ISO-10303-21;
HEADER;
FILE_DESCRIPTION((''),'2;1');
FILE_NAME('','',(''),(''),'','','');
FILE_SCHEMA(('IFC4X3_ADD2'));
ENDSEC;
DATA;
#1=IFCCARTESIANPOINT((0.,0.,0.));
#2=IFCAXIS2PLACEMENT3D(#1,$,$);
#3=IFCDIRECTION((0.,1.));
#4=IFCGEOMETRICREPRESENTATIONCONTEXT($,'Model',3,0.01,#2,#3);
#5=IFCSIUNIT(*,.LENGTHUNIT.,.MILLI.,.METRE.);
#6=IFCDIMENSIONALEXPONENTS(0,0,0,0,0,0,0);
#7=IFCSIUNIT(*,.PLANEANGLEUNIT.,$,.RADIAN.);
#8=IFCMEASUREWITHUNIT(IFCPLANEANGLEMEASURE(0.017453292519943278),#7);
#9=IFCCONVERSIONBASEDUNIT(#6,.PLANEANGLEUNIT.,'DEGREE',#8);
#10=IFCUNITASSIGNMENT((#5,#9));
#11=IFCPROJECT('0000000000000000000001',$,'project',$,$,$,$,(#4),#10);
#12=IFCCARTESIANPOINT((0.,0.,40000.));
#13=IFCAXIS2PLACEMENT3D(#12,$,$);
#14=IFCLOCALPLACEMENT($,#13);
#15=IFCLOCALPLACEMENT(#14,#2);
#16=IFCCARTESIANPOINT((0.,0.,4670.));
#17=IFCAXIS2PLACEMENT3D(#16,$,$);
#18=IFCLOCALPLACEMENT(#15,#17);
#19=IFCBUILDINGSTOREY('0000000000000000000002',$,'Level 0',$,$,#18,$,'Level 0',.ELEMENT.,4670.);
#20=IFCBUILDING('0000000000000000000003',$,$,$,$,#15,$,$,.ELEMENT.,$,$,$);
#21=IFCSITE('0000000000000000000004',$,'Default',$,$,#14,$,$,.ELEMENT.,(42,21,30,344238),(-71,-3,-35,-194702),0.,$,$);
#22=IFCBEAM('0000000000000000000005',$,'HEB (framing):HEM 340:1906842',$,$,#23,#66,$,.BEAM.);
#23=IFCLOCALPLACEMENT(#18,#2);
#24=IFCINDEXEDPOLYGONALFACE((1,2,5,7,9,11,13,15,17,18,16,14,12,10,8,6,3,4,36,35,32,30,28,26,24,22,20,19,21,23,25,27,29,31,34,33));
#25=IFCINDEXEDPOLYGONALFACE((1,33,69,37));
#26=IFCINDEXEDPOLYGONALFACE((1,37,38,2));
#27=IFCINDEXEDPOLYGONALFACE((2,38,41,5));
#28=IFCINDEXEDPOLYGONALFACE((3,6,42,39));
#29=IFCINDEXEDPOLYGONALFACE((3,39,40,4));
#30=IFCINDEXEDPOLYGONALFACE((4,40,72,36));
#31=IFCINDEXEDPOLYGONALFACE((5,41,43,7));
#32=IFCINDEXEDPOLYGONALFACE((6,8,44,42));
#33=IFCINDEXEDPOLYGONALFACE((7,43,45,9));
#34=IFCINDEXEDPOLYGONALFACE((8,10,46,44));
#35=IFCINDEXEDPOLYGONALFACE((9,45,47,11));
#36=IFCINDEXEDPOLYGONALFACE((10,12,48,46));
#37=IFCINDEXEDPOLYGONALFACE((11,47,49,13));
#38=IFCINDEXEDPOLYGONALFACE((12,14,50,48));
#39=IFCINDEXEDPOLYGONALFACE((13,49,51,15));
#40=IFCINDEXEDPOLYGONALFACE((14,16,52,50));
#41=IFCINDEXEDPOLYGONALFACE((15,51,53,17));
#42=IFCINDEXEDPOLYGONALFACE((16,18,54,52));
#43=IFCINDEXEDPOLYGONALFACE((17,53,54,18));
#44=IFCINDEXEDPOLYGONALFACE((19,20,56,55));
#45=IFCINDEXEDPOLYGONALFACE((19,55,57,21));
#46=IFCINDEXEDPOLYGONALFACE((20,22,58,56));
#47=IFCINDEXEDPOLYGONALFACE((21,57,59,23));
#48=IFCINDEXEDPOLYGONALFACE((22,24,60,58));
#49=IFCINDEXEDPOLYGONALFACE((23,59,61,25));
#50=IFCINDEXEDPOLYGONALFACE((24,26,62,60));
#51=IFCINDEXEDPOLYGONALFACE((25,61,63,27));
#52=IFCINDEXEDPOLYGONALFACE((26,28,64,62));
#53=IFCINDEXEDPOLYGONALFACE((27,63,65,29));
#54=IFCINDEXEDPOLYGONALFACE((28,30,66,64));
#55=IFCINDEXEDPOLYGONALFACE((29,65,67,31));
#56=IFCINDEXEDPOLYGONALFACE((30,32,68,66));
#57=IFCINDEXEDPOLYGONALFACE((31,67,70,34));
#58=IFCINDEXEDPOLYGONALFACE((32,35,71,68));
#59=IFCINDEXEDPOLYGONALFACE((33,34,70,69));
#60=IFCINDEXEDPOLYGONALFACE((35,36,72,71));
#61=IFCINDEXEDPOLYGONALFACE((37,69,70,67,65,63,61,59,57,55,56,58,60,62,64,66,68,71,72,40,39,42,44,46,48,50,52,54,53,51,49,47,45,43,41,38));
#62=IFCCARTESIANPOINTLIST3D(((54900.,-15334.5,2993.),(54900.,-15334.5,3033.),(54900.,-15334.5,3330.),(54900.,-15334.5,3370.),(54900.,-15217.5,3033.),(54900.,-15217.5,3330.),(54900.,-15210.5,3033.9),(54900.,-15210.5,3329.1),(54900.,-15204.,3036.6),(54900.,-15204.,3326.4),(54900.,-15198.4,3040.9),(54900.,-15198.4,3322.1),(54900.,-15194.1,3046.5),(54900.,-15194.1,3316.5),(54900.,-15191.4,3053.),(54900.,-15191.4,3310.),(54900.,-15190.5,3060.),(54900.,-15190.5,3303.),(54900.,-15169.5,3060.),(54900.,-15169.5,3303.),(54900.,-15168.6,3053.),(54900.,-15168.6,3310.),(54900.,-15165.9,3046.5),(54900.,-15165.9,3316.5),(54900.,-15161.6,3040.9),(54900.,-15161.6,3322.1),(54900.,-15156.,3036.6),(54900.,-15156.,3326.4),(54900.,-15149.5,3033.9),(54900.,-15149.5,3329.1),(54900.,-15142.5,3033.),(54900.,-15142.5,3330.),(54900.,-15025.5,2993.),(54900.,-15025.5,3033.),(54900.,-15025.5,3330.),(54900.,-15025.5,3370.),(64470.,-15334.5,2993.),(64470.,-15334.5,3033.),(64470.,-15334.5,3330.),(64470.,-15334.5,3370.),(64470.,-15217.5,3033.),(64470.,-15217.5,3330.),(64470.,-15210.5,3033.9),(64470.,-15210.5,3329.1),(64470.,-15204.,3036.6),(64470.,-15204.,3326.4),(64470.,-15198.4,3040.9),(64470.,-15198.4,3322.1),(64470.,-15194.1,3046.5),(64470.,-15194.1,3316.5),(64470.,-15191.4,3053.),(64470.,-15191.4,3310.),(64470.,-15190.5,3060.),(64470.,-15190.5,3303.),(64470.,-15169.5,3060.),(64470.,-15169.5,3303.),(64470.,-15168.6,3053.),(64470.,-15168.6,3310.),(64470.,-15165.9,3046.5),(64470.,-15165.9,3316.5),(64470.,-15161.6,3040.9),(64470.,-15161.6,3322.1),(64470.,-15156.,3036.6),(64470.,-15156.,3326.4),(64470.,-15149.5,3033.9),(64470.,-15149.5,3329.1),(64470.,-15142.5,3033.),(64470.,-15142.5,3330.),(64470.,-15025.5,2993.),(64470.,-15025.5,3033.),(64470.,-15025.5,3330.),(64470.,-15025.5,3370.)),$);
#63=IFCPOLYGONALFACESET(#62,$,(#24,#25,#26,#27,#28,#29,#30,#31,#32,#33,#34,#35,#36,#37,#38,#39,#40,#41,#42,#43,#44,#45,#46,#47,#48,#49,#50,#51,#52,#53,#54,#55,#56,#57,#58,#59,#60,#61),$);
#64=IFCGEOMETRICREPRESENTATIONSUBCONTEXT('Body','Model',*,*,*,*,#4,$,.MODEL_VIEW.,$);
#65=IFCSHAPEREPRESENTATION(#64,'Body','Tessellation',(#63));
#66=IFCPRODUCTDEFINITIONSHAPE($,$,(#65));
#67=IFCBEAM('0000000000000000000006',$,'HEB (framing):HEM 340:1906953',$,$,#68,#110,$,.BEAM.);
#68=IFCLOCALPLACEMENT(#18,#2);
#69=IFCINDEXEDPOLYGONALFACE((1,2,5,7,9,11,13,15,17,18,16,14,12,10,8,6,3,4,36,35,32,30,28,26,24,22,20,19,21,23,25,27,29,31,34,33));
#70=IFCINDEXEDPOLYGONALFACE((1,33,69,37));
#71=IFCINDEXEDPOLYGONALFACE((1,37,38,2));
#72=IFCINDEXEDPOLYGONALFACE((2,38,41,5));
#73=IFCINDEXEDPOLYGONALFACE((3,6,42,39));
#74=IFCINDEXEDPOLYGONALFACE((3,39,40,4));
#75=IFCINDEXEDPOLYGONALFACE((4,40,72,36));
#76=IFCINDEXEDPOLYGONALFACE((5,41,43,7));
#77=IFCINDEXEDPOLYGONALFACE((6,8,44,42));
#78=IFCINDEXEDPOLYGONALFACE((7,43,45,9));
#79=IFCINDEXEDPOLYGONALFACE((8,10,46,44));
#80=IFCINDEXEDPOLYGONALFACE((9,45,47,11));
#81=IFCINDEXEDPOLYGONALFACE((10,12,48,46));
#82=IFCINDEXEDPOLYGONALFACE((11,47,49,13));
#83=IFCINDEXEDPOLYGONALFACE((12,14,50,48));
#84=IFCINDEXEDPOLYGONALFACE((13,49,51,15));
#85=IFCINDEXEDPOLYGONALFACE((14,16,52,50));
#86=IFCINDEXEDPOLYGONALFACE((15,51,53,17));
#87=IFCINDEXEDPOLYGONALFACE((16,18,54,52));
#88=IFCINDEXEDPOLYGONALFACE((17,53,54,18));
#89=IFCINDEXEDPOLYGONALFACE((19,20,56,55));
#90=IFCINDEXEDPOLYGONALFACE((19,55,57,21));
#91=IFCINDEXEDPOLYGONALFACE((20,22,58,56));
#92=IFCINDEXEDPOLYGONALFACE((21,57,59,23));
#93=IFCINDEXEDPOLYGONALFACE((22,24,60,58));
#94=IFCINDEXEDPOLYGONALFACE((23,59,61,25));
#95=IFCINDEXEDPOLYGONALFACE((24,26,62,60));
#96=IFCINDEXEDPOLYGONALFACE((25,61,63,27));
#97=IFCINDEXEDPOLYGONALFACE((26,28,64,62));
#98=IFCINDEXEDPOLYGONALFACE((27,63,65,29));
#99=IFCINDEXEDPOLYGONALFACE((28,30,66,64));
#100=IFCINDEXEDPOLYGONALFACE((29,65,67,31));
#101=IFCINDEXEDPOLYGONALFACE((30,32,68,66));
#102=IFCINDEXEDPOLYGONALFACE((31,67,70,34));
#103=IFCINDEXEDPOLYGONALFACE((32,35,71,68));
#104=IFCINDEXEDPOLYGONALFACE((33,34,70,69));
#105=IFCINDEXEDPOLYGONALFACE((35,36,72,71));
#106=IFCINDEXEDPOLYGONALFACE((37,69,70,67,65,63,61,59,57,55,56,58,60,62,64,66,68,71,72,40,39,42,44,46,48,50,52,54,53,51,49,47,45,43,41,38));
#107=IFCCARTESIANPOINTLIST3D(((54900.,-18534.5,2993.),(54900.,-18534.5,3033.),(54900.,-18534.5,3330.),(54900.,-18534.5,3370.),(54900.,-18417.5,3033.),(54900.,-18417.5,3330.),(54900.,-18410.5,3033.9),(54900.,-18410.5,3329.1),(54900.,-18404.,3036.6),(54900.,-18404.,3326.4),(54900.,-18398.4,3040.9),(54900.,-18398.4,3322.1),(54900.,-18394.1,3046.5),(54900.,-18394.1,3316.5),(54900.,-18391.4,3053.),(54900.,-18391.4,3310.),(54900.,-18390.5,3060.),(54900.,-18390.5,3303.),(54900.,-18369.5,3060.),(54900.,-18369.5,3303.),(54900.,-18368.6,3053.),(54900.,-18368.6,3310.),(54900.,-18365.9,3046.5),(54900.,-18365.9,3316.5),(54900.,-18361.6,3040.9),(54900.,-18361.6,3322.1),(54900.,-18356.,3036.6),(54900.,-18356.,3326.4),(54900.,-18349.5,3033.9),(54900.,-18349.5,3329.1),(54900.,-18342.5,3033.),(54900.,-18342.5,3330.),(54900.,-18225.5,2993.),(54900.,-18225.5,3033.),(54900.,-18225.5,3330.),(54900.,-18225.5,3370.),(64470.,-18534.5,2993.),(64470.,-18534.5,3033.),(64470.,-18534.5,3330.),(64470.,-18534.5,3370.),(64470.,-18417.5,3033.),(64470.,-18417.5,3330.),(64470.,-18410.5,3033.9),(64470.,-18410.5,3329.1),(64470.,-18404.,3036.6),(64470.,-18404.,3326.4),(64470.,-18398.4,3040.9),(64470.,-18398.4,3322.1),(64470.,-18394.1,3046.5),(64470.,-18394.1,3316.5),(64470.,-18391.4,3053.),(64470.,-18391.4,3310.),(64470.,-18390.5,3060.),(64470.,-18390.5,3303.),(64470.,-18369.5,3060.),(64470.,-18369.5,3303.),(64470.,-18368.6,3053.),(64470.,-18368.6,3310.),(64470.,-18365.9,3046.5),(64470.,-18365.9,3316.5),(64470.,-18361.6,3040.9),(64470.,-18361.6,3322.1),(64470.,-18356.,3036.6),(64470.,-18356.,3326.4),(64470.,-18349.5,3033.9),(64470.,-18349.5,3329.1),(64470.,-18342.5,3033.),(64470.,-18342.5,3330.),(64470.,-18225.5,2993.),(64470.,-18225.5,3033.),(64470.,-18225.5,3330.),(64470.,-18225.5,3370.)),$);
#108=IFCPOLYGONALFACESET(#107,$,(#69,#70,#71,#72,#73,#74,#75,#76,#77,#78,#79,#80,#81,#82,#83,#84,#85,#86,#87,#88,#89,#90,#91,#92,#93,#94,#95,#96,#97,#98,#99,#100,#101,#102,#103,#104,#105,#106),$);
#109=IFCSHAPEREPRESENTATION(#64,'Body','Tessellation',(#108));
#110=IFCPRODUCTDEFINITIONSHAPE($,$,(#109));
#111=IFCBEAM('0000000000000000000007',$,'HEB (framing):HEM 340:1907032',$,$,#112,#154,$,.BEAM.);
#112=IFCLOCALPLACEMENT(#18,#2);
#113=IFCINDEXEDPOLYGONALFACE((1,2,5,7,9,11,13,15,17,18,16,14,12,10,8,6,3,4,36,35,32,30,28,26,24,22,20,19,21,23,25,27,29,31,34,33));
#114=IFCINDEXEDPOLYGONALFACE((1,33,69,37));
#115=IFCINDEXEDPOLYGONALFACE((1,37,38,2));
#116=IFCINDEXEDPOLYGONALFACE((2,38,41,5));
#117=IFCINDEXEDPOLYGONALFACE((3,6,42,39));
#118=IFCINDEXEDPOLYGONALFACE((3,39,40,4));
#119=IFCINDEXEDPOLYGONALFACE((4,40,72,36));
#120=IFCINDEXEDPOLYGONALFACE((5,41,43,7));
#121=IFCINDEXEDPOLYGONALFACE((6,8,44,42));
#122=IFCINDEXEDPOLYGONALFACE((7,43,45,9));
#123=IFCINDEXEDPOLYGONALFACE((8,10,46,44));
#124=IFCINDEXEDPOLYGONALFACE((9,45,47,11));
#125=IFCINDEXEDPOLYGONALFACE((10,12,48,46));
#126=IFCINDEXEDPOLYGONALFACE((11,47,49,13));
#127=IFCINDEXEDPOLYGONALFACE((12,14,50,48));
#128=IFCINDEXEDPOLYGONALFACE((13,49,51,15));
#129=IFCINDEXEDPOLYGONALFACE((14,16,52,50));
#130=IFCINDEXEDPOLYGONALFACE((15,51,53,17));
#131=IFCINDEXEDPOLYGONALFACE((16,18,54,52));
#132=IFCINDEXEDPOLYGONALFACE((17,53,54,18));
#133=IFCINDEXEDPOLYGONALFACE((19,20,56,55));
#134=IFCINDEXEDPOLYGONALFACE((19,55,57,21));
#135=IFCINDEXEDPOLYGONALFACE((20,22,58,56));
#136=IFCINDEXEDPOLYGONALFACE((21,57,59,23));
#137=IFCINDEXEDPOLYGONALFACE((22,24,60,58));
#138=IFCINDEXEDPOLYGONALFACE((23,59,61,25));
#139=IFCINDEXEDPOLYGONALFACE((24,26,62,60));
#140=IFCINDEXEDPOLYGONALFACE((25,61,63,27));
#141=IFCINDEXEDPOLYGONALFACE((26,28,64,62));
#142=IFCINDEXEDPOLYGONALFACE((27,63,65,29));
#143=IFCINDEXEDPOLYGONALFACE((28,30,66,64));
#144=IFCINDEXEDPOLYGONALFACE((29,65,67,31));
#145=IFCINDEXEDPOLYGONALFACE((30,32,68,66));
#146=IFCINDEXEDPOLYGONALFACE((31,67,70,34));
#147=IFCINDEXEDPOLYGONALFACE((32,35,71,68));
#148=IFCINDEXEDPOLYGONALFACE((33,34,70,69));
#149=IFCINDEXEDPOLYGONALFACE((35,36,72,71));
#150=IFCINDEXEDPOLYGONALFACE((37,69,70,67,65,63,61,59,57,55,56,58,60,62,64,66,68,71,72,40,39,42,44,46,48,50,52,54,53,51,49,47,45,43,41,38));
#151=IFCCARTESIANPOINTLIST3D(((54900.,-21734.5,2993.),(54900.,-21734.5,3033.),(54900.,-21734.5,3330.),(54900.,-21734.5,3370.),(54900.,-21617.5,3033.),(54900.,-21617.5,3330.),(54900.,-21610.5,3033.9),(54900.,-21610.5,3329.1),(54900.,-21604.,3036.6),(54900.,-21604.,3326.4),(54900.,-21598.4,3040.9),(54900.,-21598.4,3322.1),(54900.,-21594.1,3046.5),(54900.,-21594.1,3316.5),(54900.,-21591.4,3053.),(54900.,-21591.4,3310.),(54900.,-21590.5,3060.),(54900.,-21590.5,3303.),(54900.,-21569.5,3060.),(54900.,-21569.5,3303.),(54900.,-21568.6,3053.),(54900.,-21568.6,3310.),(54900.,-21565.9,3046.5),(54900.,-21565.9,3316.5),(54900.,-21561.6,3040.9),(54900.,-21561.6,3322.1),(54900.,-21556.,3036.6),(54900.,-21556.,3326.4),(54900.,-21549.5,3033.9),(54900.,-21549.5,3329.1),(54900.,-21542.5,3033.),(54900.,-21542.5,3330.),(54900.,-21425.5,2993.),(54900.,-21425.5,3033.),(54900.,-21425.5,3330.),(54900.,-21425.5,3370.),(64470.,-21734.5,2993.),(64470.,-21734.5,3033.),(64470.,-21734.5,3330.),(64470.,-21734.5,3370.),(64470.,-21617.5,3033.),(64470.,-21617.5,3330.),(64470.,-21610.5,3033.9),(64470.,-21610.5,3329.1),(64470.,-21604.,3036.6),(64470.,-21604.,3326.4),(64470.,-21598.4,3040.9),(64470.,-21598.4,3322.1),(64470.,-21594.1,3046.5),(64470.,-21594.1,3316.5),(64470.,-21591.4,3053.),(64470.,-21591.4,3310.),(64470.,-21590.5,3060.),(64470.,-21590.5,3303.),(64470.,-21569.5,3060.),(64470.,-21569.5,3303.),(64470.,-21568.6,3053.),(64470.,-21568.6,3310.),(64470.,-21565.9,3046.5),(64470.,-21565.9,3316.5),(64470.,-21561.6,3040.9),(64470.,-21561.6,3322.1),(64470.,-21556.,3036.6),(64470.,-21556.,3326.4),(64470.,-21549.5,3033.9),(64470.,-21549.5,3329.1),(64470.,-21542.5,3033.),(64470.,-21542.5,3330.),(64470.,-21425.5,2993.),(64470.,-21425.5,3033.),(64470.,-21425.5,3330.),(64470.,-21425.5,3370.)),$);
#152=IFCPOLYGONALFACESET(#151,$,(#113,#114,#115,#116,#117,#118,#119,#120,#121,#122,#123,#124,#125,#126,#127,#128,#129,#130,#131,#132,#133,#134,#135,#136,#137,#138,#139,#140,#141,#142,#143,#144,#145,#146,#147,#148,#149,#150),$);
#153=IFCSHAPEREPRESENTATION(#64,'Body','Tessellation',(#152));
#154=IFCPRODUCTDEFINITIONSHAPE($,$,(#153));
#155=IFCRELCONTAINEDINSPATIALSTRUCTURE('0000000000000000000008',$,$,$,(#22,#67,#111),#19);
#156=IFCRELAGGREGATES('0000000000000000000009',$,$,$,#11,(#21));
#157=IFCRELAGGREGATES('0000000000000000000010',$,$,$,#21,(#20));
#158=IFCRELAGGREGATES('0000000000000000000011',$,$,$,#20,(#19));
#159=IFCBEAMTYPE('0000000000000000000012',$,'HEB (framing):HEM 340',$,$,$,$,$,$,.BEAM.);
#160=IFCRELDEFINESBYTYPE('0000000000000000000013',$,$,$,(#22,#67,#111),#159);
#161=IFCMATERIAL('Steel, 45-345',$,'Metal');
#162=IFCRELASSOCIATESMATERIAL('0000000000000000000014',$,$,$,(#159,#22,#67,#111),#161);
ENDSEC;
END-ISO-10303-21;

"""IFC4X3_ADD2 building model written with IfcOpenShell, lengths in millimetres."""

from ifc_helpers import new_model, entity, si_unit, converted_unit, direction, frame, frame_2d, origin, place, context, subcontext, project, spatial, polyline, circle_curve, parameter, trimmed, segment, composite_curve, outline, extrude, source, transform, mapped, material, material_profile, profile_set, profile_usage, type_object, type_shapes, element, save


model = new_model("IFC4X3_ADD2")

# Units and contexts
model_context = context("Model", 3, precision=0.01, world=origin(), true_north=direction((0.0, 1.0)))
body_context = subcontext(model_context, "Body", "Model", "MODEL_VIEW")
ifc_project = project(units=[si_unit("LENGTHUNIT", "METRE", prefix="MILLI"), converted_unit("PLANEANGLEUNIT", "DEGREE", entity("IfcPlaneAngleMeasure", 0.017453292519943278), si_unit("PLANEANGLEUNIT", "RADIAN"), dimensions=[0, 0, 0, 0, 0, 0, 0])], contexts=[model_context])

# Site, building, storey
site_placement = place(None, frame((0.0, 0.0, 40000.0)))
site = spatial("IfcSite", under=ifc_project, at=site_placement, Name="Default", CompositionType="ELEMENT", RefLatitude=(42, 21, 30, 344238), RefLongitude=(-71, -3, -35, -194702), RefElevation=0.0)
building_placement = place(site_placement, origin())
building = spatial("IfcBuilding", under=site, at=building_placement, CompositionType="ELEMENT")
storey_placement = place(building_placement, frame((0.0, 0.0, 4670.0)))
storey = spatial("IfcBuildingStorey", under=building, at=storey_placement, Name="Level 0", LongName="Level 0", CompositionType="ELEMENT", Elevation=4670.0)

# Shared definitions
ifc_material_1 = material(Name="Steel, 45-345", Category="Metal")

# Beams
ifc_material_profile_1 = material_profile(ifc_material_1, outline(composite_curve([segment(polyline([(-154.5, -148.5), (-154.5, -188.5)]), True, "CONTINUOUS"), segment(polyline([(-154.5, -188.5), (154.5, -188.5)]), True, "CONTINUOUS"), segment(polyline([(154.5, -188.5), (154.5, -148.5)]), True, "CONTINUOUS"), segment(polyline([(154.5, -148.5), (37.5, -148.5)]), True, "CONTINUOUS"), segment(trimmed(circle_curve(frame_2d((37.5, -121.5), x_axis=(1.0, 0.0)), 27.0), [parameter(180.0)], [parameter(270.0)], True, "PARAMETER"), False, "CONTINUOUS"), segment(polyline([(10.5, -121.5), (10.5, 121.5)]), True, "CONTINUOUS"), segment(trimmed(circle_curve(frame_2d((37.5, 121.5), x_axis=(1.0, 0.0)), 27.0), [parameter(90.0)], [parameter(180.0)], True, "PARAMETER"), False, "CONTINUOUS"), segment(polyline([(37.5, 148.5), (154.5, 148.5)]), True, "CONTINUOUS"), segment(polyline([(154.5, 148.5), (154.5, 188.5)]), True, "CONTINUOUS"), segment(polyline([(154.5, 188.5), (-154.5, 188.5)]), True, "CONTINUOUS"), segment(polyline([(-154.5, 188.5), (-154.5, 148.5)]), True, "CONTINUOUS"), segment(polyline([(-154.5, 148.5), (-37.5, 148.5)]), True, "CONTINUOUS"), segment(trimmed(circle_curve(frame_2d((-37.5, 121.5), x_axis=(1.0, 0.0)), 27.0), [parameter(360.0)], [parameter(90.0)], True, "PARAMETER"), False, "CONTINUOUS"), segment(polyline([(-10.5, 121.5), (-10.5, -121.5)]), True, "CONTINUOUS"), segment(trimmed(circle_curve(frame_2d((-37.5, -121.5), x_axis=(1.0, 0.0)), 27.0), [parameter(270.0)], [parameter(0.0)], True, "PARAMETER"), False, "CONTINUOUS"), segment(polyline([(-37.5, -148.5), (-154.5, -148.5)]), True, "CONTINUOUS")], self_intersect=False)), Name="HEM 340")
ifc_profile_set_1 = profile_set([ifc_material_profile_1], Name="HEM 340")
ifc_profile_usage_1 = profile_usage(ifc_profile_set_1, cardinal=8)
beam_type_1 = type_object("IfcBeamType", Name="HEB (framing):HEM 340", PredefinedType="BEAM", material=ifc_profile_set_1)
shared_shape_1 = source(origin(), body_context, "Body", "SweptSolid", [
    extrude(outline(composite_curve([segment(polyline([(-154.5, -148.5), (-154.5, -188.5)]), True, "CONTINUOUS"), segment(polyline([(-154.5, -188.5), (154.5, -188.5)]), True, "CONTINUOUS"), segment(polyline([(154.5, -188.5), (154.5, -148.5)]), True, "CONTINUOUS"), segment(polyline([(154.5, -148.5), (37.5, -148.5)]), True, "CONTINUOUS"), segment(trimmed(circle_curve(frame_2d((37.5, -121.5), x_axis=(1.0, 0.0)), 27.0), [parameter(180.0)], [parameter(270.0)], True, "PARAMETER"), False, "CONTINUOUS"), segment(polyline([(10.5, -121.5), (10.5, 121.5)]), True, "CONTINUOUS"), segment(trimmed(circle_curve(frame_2d((37.5, 121.5), x_axis=(1.0, 0.0)), 27.0), [parameter(90.0)], [parameter(180.0)], True, "PARAMETER"), False, "CONTINUOUS"), segment(polyline([(37.5, 148.5), (154.5, 148.5)]), True, "CONTINUOUS"), segment(polyline([(154.5, 148.5), (154.5, 188.5)]), True, "CONTINUOUS"), segment(polyline([(154.5, 188.5), (-154.5, 188.5)]), True, "CONTINUOUS"), segment(polyline([(-154.5, 188.5), (-154.5, 148.5)]), True, "CONTINUOUS"), segment(polyline([(-154.5, 148.5), (-37.5, 148.5)]), True, "CONTINUOUS"), segment(trimmed(circle_curve(frame_2d((-37.5, 121.5), x_axis=(1.0, 0.0)), 27.0), [parameter(360.0)], [parameter(90.0)], True, "PARAMETER"), False, "CONTINUOUS"), segment(polyline([(-10.5, 121.5), (-10.5, -121.5)]), True, "CONTINUOUS"), segment(trimmed(circle_curve(frame_2d((-37.5, -121.5), x_axis=(1.0, 0.0)), 27.0), [parameter(270.0)], [parameter(0.0)], True, "PARAMETER"), False, "CONTINUOUS"), segment(polyline([(-37.5, -148.5), (-154.5, -148.5)]), True, "CONTINUOUS")], self_intersect=False)), frame((-4742.5, 0.0, 0.0), z_axis=(-1.0, 0.0, 0.0), x_axis=(0.0, -1.0, 0.0)), (0.0, 0.0, -1.0), 9570.0),
])
type_shapes(beam_type_1, [shared_shape_1])
for number, where, name in (
    (1, (59642.5, -15180.0, 3181.5), "HEB (framing):HEM 340:1906842"),
    (2, (59642.5, -18380.0, 3181.5), "HEB (framing):HEM 340:1906953"),
    (3, (59642.5, -21580.0, 3181.5), "HEB (framing):HEM 340:1907032"),
):
    element("IfcBeam", number, at=place(storey_placement, frame(where)), inside=storey, type_object=beam_type_1, material=ifc_profile_usage_1, Name=name, PredefinedType="BEAM", context=body_context, shape_type="MappedRepresentation", body=[
        mapped(shared_shape_1, transform((0.0, 0.0, 0.0), scale=1.0)),
    ])

save(model, "model.ifc")
